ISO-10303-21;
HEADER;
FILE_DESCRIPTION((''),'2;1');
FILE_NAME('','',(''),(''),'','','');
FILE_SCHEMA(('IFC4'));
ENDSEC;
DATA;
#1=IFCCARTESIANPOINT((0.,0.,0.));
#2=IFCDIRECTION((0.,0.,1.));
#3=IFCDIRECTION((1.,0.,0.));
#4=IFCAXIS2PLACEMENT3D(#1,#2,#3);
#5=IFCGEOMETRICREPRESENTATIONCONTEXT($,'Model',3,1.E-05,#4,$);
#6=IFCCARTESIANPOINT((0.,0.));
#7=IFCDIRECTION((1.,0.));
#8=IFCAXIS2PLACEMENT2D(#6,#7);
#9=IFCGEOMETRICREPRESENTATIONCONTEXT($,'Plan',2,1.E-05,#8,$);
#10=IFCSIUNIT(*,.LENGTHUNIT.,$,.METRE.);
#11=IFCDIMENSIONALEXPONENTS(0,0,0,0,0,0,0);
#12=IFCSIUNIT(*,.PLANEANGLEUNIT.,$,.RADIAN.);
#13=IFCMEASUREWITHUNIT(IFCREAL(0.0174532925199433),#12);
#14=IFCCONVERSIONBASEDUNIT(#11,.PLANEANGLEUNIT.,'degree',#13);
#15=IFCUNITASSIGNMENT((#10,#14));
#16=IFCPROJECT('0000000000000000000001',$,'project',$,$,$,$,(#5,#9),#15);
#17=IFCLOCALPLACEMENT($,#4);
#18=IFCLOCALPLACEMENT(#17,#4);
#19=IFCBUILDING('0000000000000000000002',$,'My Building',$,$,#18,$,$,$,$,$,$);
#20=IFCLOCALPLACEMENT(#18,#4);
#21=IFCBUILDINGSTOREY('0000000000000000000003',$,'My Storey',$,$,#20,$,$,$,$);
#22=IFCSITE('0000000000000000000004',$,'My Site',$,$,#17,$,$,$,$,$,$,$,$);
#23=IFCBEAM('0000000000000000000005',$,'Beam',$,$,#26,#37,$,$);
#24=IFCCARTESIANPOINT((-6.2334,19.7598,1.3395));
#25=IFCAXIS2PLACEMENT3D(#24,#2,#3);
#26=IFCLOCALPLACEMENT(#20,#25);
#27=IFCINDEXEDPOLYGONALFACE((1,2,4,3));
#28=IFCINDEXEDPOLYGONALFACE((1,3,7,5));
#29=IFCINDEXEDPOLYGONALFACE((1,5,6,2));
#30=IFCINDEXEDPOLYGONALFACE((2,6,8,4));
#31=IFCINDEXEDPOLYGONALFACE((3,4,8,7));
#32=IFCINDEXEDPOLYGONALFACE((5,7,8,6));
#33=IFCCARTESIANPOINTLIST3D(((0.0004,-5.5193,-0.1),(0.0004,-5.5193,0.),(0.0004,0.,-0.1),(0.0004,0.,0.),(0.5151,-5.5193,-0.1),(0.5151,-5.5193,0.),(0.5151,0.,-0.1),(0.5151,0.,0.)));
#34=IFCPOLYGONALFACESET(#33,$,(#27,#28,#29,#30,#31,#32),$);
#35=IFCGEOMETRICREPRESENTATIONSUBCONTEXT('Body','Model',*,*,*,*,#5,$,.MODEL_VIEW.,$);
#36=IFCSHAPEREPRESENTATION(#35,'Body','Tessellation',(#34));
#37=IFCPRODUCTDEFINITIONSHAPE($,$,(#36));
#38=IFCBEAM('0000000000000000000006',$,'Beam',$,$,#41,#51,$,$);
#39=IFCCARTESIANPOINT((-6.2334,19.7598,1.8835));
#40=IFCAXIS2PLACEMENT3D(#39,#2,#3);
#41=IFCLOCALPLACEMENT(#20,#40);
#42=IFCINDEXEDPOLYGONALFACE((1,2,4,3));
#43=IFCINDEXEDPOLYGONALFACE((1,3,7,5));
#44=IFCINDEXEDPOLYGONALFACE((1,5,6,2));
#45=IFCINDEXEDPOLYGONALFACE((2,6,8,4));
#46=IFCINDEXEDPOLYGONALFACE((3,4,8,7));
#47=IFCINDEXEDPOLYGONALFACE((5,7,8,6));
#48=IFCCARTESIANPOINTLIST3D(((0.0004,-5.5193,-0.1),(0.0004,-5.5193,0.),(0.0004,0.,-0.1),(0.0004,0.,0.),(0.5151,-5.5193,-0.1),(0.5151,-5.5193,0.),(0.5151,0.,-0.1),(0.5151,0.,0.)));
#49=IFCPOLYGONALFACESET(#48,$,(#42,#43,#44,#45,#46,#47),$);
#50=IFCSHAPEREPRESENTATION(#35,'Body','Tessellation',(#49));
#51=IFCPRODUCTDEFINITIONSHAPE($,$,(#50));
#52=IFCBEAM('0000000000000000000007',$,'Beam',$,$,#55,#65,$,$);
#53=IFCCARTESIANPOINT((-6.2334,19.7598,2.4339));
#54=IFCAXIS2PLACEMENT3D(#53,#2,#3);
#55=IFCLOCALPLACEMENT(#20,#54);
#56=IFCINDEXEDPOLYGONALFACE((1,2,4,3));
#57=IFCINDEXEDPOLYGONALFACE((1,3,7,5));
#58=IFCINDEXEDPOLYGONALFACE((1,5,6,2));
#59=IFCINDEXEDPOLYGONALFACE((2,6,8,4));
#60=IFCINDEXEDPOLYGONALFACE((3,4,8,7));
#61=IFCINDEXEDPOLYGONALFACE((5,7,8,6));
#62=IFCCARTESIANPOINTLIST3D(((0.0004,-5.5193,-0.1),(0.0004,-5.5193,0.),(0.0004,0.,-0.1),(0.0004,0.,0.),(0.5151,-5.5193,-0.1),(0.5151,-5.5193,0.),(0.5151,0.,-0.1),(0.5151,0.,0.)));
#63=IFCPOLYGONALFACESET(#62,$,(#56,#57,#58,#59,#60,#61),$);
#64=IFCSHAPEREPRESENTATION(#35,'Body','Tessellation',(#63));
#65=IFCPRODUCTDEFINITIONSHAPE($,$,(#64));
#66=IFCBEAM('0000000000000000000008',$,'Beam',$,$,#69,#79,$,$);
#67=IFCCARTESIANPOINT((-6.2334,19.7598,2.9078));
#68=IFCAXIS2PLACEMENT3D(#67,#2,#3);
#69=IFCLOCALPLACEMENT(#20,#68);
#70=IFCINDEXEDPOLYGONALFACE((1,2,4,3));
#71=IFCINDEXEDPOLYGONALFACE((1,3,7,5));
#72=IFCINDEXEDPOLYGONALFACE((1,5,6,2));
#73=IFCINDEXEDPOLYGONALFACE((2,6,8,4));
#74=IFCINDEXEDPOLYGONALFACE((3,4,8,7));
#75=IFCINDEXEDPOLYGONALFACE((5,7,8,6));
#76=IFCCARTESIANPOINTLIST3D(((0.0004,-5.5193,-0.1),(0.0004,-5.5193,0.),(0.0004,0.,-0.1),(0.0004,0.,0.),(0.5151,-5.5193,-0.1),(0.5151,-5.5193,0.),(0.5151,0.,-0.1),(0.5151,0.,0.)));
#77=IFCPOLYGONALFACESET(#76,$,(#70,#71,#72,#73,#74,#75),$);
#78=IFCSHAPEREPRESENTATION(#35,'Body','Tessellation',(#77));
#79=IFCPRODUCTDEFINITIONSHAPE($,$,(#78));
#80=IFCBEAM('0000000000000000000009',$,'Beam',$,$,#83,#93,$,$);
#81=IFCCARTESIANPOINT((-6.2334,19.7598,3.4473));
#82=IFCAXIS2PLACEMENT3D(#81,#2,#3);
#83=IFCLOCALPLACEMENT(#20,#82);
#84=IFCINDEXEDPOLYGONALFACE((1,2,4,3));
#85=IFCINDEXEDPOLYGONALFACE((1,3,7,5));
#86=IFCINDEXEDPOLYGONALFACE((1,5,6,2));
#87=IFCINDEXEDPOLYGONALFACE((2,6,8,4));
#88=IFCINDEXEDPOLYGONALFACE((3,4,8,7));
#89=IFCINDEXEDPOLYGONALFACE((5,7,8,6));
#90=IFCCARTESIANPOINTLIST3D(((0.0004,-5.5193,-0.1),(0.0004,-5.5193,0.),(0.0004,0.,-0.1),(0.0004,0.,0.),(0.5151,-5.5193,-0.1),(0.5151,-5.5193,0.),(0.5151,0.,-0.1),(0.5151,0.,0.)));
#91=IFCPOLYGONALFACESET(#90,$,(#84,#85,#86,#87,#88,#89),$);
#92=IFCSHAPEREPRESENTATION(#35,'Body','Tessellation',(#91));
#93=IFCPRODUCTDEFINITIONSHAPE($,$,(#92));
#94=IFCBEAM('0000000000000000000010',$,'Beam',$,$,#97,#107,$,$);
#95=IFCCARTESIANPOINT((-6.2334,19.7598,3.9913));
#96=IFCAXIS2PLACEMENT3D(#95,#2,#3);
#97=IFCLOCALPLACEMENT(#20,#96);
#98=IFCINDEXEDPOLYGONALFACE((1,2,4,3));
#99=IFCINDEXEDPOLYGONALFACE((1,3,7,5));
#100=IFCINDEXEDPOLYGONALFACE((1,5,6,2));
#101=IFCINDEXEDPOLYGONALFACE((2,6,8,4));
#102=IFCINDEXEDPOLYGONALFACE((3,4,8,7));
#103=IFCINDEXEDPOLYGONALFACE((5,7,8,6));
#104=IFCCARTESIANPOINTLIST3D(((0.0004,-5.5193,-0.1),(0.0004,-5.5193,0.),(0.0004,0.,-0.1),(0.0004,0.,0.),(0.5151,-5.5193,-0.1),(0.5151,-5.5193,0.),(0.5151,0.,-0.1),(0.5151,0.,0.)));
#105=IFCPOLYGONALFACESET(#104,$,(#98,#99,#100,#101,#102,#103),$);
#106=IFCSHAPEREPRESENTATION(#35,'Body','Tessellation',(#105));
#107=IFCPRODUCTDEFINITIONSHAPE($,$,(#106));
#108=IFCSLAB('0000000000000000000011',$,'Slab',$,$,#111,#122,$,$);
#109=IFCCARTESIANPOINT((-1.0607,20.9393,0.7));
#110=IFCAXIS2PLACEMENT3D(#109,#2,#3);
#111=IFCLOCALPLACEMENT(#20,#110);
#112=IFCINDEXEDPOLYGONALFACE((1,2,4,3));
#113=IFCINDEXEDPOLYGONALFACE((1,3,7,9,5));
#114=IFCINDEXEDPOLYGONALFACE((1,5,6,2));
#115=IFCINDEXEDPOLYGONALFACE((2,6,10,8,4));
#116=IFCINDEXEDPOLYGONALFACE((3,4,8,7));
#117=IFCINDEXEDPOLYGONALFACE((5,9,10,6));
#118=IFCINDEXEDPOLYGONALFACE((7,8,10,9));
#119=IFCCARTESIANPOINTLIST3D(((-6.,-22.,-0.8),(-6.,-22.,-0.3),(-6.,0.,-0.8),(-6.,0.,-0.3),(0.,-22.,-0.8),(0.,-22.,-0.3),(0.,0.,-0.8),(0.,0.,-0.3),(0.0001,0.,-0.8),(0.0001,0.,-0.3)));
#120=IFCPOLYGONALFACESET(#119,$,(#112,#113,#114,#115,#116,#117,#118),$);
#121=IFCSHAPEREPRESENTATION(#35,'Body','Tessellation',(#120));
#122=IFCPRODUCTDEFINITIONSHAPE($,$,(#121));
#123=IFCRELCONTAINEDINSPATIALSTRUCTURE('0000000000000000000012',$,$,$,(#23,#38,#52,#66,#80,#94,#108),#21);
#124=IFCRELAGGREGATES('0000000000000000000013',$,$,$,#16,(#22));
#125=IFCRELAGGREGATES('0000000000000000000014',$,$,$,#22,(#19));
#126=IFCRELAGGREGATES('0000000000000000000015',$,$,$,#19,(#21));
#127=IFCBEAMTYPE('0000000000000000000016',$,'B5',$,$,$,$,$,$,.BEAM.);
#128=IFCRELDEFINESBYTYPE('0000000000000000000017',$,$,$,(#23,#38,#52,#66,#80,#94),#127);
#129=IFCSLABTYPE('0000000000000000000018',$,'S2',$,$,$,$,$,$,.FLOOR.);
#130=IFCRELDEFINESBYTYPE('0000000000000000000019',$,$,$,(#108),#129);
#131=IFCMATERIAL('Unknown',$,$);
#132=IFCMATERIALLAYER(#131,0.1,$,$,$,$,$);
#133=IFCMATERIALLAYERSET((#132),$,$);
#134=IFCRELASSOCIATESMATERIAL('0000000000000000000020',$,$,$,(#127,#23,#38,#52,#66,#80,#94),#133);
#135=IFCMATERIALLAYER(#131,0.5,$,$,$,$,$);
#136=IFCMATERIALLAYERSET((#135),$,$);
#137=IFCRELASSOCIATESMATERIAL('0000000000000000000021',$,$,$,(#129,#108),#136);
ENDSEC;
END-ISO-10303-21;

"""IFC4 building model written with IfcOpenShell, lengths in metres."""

from ifc_helpers import new_model, entity, si_unit, converted_unit, frame, origin_with_axes, origin_2d_with_axis, place, context, subcontext, project, spatial, indexed_curve, outline, extrude, material, layer, layer_set, layer_usage, type_object, element, save


model = new_model("IFC4")

# Units and contexts
model_context = context("Model", 3, precision=1e-05, world=origin_with_axes())
plan_context = context("Plan", 2, precision=1e-05, world=origin_2d_with_axis())
body_context = subcontext(model_context, "Body", "Model", "MODEL_VIEW")
ifc_project = project(units=[si_unit("LENGTHUNIT", "METRE"), converted_unit("PLANEANGLEUNIT", "degree", entity("IfcReal", 0.0174532925199433), si_unit("PLANEANGLEUNIT", "RADIAN"), dimensions=[0, 0, 0, 0, 0, 0, 0])], contexts=[model_context, plan_context])

# Site, building, storey
site_placement = place(None, origin_with_axes())
site = spatial("IfcSite", under=ifc_project, at=site_placement, Name="My Site")
building_placement = place(site_placement, origin_with_axes())
building = spatial("IfcBuilding", under=site, at=building_placement, Name="My Building")
storey_placement = place(building_placement, origin_with_axes())
storey = spatial("IfcBuildingStorey", under=building, at=storey_placement, Name="My Storey")

# Shared definitions
ifc_material = material(Name="Unknown")

# Beams
ifc_layer_1 = layer(ifc_material, 0.1)
ifc_layer_set_1 = layer_set([ifc_layer_1])
ifc_layer_usage_1 = layer_usage(ifc_layer_set_1, "AXIS3", "POSITIVE", -0.1)
beam_type_1 = type_object("IfcBeamType", Name="B5", PredefinedType="BEAM", material=ifc_layer_set_1)
beam_1_placement = place(storey_placement, frame((-6.2334, 19.7598, 1.3395), z_axis=(0.0, 0.0, 1.0), x_axis=(1.0, 0.0, 0.0)))
element("IfcBeam", 1, at=beam_1_placement, inside=storey, type_object=beam_type_1, material=ifc_layer_usage_1, Name="Beam", context=body_context, shape_type="SweptSolid", body=[
    extrude(outline(indexed_curve([(0.0, 0.0), (0.5151, 0.0), (0.5151, -5.5193), (0.0004, -5.5193), (0.0004, 0.0), (0.0, 0.0)])), frame((0.0, 0.0, -0.1), z_axis=(0.0, 0.0, 1.0), x_axis=(1.0, 0.0, 0.0)), (0.0, 0.0, 1.0), 0.1),
])
ifc_layer_usage_2 = layer_usage(ifc_layer_set_1, "AXIS3", "POSITIVE", -0.1)
beam_2_placement = place(storey_placement, frame((-6.2334, 19.7598, 1.8835), z_axis=(0.0, 0.0, 1.0), x_axis=(1.0, 0.0, 0.0)))
element("IfcBeam", 2, at=beam_2_placement, inside=storey, type_object=beam_type_1, material=ifc_layer_usage_2, Name="Beam", context=body_context, shape_type="SweptSolid", body=[
    extrude(outline(indexed_curve([(0.0, 0.0), (0.5151, 0.0), (0.5151, -5.5193), (0.0004, -5.5193), (0.0004, 0.0), (0.0, 0.0)])), frame((0.0, 0.0, -0.1), z_axis=(0.0, 0.0, 1.0), x_axis=(1.0, 0.0, 0.0)), (0.0, 0.0, 1.0), 0.1),
])
ifc_layer_usage_3 = layer_usage(ifc_layer_set_1, "AXIS3", "POSITIVE", -0.1)
beam_3_placement = place(storey_placement, frame((-6.2334, 19.7598, 2.4339), z_axis=(0.0, 0.0, 1.0), x_axis=(1.0, 0.0, 0.0)))
element("IfcBeam", 3, at=beam_3_placement, inside=storey, type_object=beam_type_1, material=ifc_layer_usage_3, Name="Beam", context=body_context, shape_type="SweptSolid", body=[
    extrude(outline(indexed_curve([(0.0, 0.0), (0.5151, 0.0), (0.5151, -5.5193), (0.0004, -5.5193), (0.0004, 0.0), (0.0, 0.0)])), frame((0.0, 0.0, -0.1), z_axis=(0.0, 0.0, 1.0), x_axis=(1.0, 0.0, 0.0)), (0.0, 0.0, 1.0), 0.1),
])
ifc_layer_usage_4 = layer_usage(ifc_layer_set_1, "AXIS3", "POSITIVE", -0.1)
beam_4_placement = place(storey_placement, frame((-6.2334, 19.7598, 2.9078), z_axis=(0.0, 0.0, 1.0), x_axis=(1.0, 0.0, 0.0)))
element("IfcBeam", 4, at=beam_4_placement, inside=storey, type_object=beam_type_1, material=ifc_layer_usage_4, Name="Beam", context=body_context, shape_type="SweptSolid", body=[
    extrude(outline(indexed_curve([(0.0, 0.0), (0.5151, 0.0), (0.5151, -5.5193), (0.0004, -5.5193), (0.0004, 0.0), (0.0, 0.0)])), frame((0.0, 0.0, -0.1), z_axis=(0.0, 0.0, 1.0), x_axis=(1.0, 0.0, 0.0)), (0.0, 0.0, 1.0), 0.1),
])
ifc_layer_usage_5 = layer_usage(ifc_layer_set_1, "AXIS3", "POSITIVE", -0.1)
beam_5_placement = place(storey_placement, frame((-6.2334, 19.7598, 3.4473), z_axis=(0.0, 0.0, 1.0), x_axis=(1.0, 0.0, 0.0)))
element("IfcBeam", 5, at=beam_5_placement, inside=storey, type_object=beam_type_1, material=ifc_layer_usage_5, Name="Beam", context=body_context, shape_type="SweptSolid", body=[
    extrude(outline(indexed_curve([(0.0, 0.0), (0.5151, 0.0), (0.5151, -5.5193), (0.0004, -5.5193), (0.0004, 0.0), (0.0, 0.0)])), frame((0.0, 0.0, -0.1), z_axis=(0.0, 0.0, 1.0), x_axis=(1.0, 0.0, 0.0)), (0.0, 0.0, 1.0), 0.1),
])
ifc_layer_usage_6 = layer_usage(ifc_layer_set_1, "AXIS3", "POSITIVE", -0.1)
beam_6_placement = place(storey_placement, frame((-6.2334, 19.7598, 3.9913), z_axis=(0.0, 0.0, 1.0), x_axis=(1.0, 0.0, 0.0)))
element("IfcBeam", 6, at=beam_6_placement, inside=storey, type_object=beam_type_1, material=ifc_layer_usage_6, Name="Beam", context=body_context, shape_type="SweptSolid", body=[
    extrude(outline(indexed_curve([(0.0, 0.0), (0.5151, 0.0), (0.5151, -5.5193), (0.0004, -5.5193), (0.0004, 0.0), (0.0, 0.0)])), frame((0.0, 0.0, -0.1), z_axis=(0.0, 0.0, 1.0), x_axis=(1.0, 0.0, 0.0)), (0.0, 0.0, 1.0), 0.1),
])

# Slab
ifc_layer_2 = layer(ifc_material, 0.5)
ifc_layer_set_2 = layer_set([ifc_layer_2])
ifc_layer_usage_7 = layer_usage(ifc_layer_set_2, "AXIS3", "POSITIVE", -0.8)
slab_type = type_object("IfcSlabType", Name="S2", PredefinedType="FLOOR", material=ifc_layer_set_2)
slab_placement = place(storey_placement, frame((-1.0607, 20.9393, 0.7), z_axis=(0.0, 0.0, 1.0), x_axis=(1.0, 0.0, 0.0)))
element("IfcSlab", 7, at=slab_placement, inside=storey, type_object=slab_type, material=ifc_layer_usage_7, Name="Slab", context=body_context, shape_type="SweptSolid", body=[
    extrude(outline(indexed_curve([(0.0, 0.0), (-6.0, 0.0), (-6.0, -22.0), (0.0, -22.0), (0.0001, 0.0), (0.0, 0.0)])), frame((0.0, 0.0, -0.8), z_axis=(0.0, 0.0, 1.0), x_axis=(1.0, 0.0, 0.0)), (0.0, 0.0, 1.0), 0.5),
])

save(model, "model.ifc")
